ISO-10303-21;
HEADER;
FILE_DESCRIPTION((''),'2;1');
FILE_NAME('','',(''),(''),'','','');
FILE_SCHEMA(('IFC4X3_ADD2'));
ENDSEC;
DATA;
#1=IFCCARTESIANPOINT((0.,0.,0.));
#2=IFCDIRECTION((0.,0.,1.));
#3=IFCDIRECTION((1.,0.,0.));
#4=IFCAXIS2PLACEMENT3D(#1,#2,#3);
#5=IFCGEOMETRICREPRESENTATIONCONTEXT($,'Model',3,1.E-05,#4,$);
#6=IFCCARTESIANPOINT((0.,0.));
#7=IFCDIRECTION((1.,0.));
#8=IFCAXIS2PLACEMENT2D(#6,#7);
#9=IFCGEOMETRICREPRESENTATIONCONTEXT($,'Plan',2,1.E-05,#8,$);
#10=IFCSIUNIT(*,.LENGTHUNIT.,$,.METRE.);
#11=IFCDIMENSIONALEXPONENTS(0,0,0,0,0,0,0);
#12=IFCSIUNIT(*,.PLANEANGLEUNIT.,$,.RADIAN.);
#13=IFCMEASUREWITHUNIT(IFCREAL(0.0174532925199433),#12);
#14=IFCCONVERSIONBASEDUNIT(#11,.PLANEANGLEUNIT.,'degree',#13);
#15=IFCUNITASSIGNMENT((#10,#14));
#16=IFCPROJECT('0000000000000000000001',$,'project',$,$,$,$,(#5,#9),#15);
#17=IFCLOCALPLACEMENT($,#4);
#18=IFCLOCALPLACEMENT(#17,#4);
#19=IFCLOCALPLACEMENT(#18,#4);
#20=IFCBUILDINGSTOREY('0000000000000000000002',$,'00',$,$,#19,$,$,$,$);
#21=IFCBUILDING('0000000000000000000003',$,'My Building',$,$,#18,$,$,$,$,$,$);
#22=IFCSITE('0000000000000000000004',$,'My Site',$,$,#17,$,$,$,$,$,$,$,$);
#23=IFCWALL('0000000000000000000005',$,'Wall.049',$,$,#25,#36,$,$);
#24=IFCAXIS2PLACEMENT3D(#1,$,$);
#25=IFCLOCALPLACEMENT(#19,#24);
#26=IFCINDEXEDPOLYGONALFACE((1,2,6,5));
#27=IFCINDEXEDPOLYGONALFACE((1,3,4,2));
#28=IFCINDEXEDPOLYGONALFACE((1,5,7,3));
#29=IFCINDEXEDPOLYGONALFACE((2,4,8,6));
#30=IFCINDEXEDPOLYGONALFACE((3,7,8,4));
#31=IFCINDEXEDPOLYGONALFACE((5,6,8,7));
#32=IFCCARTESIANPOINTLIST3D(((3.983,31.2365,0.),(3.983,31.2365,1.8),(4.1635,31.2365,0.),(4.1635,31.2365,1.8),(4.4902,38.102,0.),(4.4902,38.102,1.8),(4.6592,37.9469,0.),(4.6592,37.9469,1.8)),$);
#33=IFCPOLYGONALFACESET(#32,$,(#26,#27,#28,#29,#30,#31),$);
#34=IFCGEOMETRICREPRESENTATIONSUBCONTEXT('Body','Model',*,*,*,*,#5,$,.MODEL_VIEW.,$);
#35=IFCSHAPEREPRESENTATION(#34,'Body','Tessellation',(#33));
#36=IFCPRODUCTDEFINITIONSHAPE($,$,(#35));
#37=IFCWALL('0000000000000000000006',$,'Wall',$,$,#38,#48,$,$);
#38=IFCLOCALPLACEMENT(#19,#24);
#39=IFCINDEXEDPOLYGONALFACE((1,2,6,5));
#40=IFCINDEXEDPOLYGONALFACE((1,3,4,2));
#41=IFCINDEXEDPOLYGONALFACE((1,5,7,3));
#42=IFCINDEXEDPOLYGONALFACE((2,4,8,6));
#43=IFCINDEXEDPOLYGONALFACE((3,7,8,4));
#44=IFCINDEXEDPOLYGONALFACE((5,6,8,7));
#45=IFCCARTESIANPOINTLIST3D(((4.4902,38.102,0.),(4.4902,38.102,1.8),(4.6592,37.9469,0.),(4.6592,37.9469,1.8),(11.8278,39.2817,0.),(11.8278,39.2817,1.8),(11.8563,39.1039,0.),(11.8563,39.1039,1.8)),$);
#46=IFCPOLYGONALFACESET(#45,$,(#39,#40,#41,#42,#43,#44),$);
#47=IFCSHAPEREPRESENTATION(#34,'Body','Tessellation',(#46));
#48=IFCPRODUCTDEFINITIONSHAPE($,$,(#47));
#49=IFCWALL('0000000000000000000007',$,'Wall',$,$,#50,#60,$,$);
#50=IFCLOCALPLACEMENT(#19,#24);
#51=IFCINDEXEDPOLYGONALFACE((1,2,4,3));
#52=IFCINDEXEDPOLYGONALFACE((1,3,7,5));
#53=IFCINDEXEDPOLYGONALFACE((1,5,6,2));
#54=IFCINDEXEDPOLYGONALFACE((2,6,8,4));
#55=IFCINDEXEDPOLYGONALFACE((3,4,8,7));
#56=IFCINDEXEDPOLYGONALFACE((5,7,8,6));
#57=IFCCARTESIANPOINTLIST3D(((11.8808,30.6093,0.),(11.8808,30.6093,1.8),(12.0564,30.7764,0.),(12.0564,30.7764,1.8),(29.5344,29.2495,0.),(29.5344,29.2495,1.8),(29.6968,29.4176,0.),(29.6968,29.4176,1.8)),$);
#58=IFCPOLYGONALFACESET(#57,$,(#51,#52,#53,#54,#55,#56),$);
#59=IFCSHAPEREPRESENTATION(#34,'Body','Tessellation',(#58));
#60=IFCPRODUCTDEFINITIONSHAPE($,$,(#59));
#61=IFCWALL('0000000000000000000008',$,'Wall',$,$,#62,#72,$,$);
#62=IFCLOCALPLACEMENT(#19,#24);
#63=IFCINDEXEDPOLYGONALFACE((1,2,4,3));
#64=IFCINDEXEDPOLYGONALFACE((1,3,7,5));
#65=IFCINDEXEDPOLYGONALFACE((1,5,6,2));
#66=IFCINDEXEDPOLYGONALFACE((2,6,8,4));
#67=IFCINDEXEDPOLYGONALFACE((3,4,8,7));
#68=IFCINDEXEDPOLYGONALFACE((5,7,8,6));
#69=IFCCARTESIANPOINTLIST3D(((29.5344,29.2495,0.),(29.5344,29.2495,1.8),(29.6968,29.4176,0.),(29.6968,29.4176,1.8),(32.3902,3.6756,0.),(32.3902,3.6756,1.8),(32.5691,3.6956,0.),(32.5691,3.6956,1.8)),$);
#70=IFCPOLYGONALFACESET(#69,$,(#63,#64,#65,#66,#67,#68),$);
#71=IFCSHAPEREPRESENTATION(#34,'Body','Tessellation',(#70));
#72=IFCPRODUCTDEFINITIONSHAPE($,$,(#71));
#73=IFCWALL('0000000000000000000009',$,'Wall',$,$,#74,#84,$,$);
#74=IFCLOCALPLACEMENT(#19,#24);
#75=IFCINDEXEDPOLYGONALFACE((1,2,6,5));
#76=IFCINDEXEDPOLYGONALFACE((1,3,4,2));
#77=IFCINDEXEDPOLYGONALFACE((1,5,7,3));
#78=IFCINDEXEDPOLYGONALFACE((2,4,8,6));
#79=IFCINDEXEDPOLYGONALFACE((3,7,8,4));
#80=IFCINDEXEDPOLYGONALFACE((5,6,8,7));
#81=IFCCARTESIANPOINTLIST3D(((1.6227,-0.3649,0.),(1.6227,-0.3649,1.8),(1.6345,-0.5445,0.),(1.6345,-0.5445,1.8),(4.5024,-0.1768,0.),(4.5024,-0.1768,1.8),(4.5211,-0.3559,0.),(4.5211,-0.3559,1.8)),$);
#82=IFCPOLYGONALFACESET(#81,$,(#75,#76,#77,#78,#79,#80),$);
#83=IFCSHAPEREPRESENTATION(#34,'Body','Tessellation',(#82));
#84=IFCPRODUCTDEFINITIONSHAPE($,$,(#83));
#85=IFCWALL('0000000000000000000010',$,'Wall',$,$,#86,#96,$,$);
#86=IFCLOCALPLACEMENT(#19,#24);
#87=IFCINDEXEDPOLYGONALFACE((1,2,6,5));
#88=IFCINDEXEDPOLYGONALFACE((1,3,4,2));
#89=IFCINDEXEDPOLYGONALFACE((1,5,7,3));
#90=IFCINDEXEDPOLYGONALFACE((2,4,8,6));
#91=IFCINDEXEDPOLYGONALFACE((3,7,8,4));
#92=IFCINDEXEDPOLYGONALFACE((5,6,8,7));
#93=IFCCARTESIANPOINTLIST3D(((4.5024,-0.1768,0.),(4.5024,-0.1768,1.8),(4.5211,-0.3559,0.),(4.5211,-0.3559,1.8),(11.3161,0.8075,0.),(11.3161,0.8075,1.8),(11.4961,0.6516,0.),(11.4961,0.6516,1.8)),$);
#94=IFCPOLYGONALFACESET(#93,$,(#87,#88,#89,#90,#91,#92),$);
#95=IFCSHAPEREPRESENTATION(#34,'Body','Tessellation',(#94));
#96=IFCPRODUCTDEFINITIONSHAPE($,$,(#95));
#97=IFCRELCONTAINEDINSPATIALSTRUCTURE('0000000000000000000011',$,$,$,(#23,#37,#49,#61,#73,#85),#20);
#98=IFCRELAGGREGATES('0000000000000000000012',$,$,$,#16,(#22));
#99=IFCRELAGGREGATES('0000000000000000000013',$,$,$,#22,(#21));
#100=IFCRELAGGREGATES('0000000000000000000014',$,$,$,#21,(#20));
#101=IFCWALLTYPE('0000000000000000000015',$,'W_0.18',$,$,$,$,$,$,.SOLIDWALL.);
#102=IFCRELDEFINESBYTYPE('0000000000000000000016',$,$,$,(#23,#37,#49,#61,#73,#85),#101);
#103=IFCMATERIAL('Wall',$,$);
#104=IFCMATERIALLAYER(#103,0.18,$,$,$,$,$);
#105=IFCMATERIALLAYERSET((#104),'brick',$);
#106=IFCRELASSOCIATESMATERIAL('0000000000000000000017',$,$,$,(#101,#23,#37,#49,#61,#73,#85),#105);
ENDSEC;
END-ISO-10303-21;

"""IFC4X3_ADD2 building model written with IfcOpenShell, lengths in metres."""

from ifc_helpers import new_model, entity, si_unit, converted_unit, frame, origin_with_axes, origin_2d_with_axis, place, context, subcontext, project, spatial, line, indexed_curve, outline, extrude, material, layer, layer_set, layer_usage, type_object, element, save


model = new_model("IFC4X3_ADD2")

# Units and contexts
model_context = context("Model", 3, precision=1e-05, world=origin_with_axes())
plan_context = context("Plan", 2, precision=1e-05, world=origin_2d_with_axis())
body_context_1 = subcontext(model_context, "Body", "Model", "MODEL_VIEW")
ifc_project = project(units=[si_unit("LENGTHUNIT", "METRE"), converted_unit("PLANEANGLEUNIT", "degree", entity("IfcReal", 0.0174532925199433), si_unit("PLANEANGLEUNIT", "RADIAN"), dimensions=[0, 0, 0, 0, 0, 0, 0])], contexts=[model_context, plan_context])

# Site, building, storey
site_placement = place(None, origin_with_axes())
site = spatial("IfcSite", under=ifc_project, at=site_placement, Name="My Site")
building_placement = place(site_placement, origin_with_axes())
building = spatial("IfcBuilding", under=site, at=building_placement, Name="My Building")
storey_placement = place(building_placement, origin_with_axes())
storey = spatial("IfcBuildingStorey", under=building, at=storey_placement, Name="00")

# Walls
ifc_material_1 = material(Name="Wall")
ifc_layer_1 = layer(ifc_material_1, 0.18)
ifc_layer_set_1 = layer_set([ifc_layer_1], Name="brick")
ifc_layer_usage_1 = layer_usage(ifc_layer_set_1, "AXIS2", "POSITIVE", 0.0)
wall_type_1 = type_object("IfcWallType", Name="W_0.18", PredefinedType="SOLIDWALL", material=ifc_layer_set_1)
wall_1_placement = place(storey_placement, frame((4.4902, 38.102, 0.0), z_axis=(0.0, 0.0, 1.0), x_axis=(-0.073678, -0.997282, 0.0)))
element("IfcWall", 1, at=wall_1_placement, inside=storey, type_object=wall_type_1, material=ifc_layer_usage_1, Name="Wall.049", context=body_context_1, shape_type="SweptSolid", body=[
    extrude(outline(indexed_curve([(0.0, 0.0), (0.1423, 0.18), (6.871, 0.18), (6.8843, 0.0)], segments=[line(1, 2, 3, 4, 1)])), origin_with_axes(), (0.0, 0.0, 1.0), 1.8),
])
ifc_layer_usage_2 = layer_usage(ifc_layer_set_1, "AXIS2", "POSITIVE", 0.0)
wall_2_placement = place(storey_placement, frame((11.8278, 39.2817, 0.0), z_axis=(0.0, 0.0, 1.0), x_axis=(-0.987322, -0.158732, 0.0)))
element("IfcWall", 2, at=wall_2_placement, inside=storey, type_object=wall_type_1, material=ifc_layer_usage_2, Name="Wall", context=body_context_1, shape_type="SweptSolid", body=[
    extrude(outline(indexed_curve([(0.0, 0.0), (0.0, 0.18), (7.2895, 0.18), (7.4318, 0.0)], segments=[line(1, 2, 3, 4, 1)])), origin_with_axes(), (0.0, 0.0, 1.0), 1.8),
])
ifc_layer_usage_3 = layer_usage(ifc_layer_set_1, "AXIS2", "POSITIVE", 0.0)
wall_3_placement = place(storey_placement, frame((29.6968, 29.4176, 0.0), z_axis=(0.0, 0.0, 1.0), x_axis=(-0.997047, 0.076799, 0.0)))
element("IfcWall", 3, at=wall_3_placement, inside=storey, type_object=wall_type_1, material=ifc_layer_usage_3, Name="Wall", context=body_context_1, shape_type="SweptSolid", body=[
    extrude(outline(indexed_curve([(0.0, 0.0), (0.149, 0.18), (17.8549, 0.18), (17.6927, 0.0)], segments=[line(1, 2, 3, 4, 1)])), origin_with_axes(), (0.0, 0.0, 1.0), 1.8),
])
ifc_layer_usage_4 = layer_usage(ifc_layer_set_1, "AXIS2", "POSITIVE", 0.0)
wall_4_placement = place(storey_placement, frame((32.5691, 3.6956, 0.0), z_axis=(0.0, 0.0, 1.0), x_axis=(-0.110978, 0.993823, 0.0)))
element("IfcWall", 4, at=wall_4_placement, inside=storey, type_object=wall_type_1, material=ifc_layer_usage_4, Name="Wall", context=body_context_1, shape_type="SweptSolid", body=[
    extrude(outline(indexed_curve([(0.0, 0.0), (0.0, 0.18), (25.7329, 0.18), (25.8819, 0.0)], segments=[line(1, 2, 3, 4, 1)])), origin_with_axes(), (0.0, 0.0, 1.0), 1.8),
])
ifc_layer_usage_5 = layer_usage(ifc_layer_set_1, "AXIS2", "POSITIVE", 0.0)
wall_5_placement = place(storey_placement, frame((1.6345, -0.5445, 0.0), z_axis=(0.0, 0.0, 1.0), x_axis=(0.997874, 0.065175, 0.0)))
element("IfcWall", 5, at=wall_5_placement, inside=storey, type_object=wall_type_1, material=ifc_layer_usage_5, Name="Wall", context=body_context_1, shape_type="SweptSolid", body=[
    extrude(outline(indexed_curve([(0.0, 0.0), (0.0, 0.18), (2.8858, 0.18), (2.8928, 0.0)], segments=[line(1, 2, 3, 4, 1)])), origin_with_axes(), (0.0, 0.0, 1.0), 1.8),
])
ifc_layer_usage_6 = layer_usage(ifc_layer_set_1, "AXIS2", "POSITIVE", 0.0)
wall_6_placement = place(storey_placement, frame((4.5211, -0.3559, 0.0), z_axis=(0.0, 0.0, 1.0), x_axis=(0.989728, 0.142965, 0.0)))
element("IfcWall", 6, at=wall_6_placement, inside=storey, type_object=wall_type_1, material=ifc_layer_usage_6, Name="Wall", context=body_context_1, shape_type="SweptSolid", body=[
    extrude(outline(indexed_curve([(0.0, 0.0), (0.007, 0.18), (6.8915, 0.18), (7.0473, 0.0)], segments=[line(1, 2, 3, 4, 1)])), origin_with_axes(), (0.0, 0.0, 1.0), 1.8),
])

save(model, "model.ifc")
